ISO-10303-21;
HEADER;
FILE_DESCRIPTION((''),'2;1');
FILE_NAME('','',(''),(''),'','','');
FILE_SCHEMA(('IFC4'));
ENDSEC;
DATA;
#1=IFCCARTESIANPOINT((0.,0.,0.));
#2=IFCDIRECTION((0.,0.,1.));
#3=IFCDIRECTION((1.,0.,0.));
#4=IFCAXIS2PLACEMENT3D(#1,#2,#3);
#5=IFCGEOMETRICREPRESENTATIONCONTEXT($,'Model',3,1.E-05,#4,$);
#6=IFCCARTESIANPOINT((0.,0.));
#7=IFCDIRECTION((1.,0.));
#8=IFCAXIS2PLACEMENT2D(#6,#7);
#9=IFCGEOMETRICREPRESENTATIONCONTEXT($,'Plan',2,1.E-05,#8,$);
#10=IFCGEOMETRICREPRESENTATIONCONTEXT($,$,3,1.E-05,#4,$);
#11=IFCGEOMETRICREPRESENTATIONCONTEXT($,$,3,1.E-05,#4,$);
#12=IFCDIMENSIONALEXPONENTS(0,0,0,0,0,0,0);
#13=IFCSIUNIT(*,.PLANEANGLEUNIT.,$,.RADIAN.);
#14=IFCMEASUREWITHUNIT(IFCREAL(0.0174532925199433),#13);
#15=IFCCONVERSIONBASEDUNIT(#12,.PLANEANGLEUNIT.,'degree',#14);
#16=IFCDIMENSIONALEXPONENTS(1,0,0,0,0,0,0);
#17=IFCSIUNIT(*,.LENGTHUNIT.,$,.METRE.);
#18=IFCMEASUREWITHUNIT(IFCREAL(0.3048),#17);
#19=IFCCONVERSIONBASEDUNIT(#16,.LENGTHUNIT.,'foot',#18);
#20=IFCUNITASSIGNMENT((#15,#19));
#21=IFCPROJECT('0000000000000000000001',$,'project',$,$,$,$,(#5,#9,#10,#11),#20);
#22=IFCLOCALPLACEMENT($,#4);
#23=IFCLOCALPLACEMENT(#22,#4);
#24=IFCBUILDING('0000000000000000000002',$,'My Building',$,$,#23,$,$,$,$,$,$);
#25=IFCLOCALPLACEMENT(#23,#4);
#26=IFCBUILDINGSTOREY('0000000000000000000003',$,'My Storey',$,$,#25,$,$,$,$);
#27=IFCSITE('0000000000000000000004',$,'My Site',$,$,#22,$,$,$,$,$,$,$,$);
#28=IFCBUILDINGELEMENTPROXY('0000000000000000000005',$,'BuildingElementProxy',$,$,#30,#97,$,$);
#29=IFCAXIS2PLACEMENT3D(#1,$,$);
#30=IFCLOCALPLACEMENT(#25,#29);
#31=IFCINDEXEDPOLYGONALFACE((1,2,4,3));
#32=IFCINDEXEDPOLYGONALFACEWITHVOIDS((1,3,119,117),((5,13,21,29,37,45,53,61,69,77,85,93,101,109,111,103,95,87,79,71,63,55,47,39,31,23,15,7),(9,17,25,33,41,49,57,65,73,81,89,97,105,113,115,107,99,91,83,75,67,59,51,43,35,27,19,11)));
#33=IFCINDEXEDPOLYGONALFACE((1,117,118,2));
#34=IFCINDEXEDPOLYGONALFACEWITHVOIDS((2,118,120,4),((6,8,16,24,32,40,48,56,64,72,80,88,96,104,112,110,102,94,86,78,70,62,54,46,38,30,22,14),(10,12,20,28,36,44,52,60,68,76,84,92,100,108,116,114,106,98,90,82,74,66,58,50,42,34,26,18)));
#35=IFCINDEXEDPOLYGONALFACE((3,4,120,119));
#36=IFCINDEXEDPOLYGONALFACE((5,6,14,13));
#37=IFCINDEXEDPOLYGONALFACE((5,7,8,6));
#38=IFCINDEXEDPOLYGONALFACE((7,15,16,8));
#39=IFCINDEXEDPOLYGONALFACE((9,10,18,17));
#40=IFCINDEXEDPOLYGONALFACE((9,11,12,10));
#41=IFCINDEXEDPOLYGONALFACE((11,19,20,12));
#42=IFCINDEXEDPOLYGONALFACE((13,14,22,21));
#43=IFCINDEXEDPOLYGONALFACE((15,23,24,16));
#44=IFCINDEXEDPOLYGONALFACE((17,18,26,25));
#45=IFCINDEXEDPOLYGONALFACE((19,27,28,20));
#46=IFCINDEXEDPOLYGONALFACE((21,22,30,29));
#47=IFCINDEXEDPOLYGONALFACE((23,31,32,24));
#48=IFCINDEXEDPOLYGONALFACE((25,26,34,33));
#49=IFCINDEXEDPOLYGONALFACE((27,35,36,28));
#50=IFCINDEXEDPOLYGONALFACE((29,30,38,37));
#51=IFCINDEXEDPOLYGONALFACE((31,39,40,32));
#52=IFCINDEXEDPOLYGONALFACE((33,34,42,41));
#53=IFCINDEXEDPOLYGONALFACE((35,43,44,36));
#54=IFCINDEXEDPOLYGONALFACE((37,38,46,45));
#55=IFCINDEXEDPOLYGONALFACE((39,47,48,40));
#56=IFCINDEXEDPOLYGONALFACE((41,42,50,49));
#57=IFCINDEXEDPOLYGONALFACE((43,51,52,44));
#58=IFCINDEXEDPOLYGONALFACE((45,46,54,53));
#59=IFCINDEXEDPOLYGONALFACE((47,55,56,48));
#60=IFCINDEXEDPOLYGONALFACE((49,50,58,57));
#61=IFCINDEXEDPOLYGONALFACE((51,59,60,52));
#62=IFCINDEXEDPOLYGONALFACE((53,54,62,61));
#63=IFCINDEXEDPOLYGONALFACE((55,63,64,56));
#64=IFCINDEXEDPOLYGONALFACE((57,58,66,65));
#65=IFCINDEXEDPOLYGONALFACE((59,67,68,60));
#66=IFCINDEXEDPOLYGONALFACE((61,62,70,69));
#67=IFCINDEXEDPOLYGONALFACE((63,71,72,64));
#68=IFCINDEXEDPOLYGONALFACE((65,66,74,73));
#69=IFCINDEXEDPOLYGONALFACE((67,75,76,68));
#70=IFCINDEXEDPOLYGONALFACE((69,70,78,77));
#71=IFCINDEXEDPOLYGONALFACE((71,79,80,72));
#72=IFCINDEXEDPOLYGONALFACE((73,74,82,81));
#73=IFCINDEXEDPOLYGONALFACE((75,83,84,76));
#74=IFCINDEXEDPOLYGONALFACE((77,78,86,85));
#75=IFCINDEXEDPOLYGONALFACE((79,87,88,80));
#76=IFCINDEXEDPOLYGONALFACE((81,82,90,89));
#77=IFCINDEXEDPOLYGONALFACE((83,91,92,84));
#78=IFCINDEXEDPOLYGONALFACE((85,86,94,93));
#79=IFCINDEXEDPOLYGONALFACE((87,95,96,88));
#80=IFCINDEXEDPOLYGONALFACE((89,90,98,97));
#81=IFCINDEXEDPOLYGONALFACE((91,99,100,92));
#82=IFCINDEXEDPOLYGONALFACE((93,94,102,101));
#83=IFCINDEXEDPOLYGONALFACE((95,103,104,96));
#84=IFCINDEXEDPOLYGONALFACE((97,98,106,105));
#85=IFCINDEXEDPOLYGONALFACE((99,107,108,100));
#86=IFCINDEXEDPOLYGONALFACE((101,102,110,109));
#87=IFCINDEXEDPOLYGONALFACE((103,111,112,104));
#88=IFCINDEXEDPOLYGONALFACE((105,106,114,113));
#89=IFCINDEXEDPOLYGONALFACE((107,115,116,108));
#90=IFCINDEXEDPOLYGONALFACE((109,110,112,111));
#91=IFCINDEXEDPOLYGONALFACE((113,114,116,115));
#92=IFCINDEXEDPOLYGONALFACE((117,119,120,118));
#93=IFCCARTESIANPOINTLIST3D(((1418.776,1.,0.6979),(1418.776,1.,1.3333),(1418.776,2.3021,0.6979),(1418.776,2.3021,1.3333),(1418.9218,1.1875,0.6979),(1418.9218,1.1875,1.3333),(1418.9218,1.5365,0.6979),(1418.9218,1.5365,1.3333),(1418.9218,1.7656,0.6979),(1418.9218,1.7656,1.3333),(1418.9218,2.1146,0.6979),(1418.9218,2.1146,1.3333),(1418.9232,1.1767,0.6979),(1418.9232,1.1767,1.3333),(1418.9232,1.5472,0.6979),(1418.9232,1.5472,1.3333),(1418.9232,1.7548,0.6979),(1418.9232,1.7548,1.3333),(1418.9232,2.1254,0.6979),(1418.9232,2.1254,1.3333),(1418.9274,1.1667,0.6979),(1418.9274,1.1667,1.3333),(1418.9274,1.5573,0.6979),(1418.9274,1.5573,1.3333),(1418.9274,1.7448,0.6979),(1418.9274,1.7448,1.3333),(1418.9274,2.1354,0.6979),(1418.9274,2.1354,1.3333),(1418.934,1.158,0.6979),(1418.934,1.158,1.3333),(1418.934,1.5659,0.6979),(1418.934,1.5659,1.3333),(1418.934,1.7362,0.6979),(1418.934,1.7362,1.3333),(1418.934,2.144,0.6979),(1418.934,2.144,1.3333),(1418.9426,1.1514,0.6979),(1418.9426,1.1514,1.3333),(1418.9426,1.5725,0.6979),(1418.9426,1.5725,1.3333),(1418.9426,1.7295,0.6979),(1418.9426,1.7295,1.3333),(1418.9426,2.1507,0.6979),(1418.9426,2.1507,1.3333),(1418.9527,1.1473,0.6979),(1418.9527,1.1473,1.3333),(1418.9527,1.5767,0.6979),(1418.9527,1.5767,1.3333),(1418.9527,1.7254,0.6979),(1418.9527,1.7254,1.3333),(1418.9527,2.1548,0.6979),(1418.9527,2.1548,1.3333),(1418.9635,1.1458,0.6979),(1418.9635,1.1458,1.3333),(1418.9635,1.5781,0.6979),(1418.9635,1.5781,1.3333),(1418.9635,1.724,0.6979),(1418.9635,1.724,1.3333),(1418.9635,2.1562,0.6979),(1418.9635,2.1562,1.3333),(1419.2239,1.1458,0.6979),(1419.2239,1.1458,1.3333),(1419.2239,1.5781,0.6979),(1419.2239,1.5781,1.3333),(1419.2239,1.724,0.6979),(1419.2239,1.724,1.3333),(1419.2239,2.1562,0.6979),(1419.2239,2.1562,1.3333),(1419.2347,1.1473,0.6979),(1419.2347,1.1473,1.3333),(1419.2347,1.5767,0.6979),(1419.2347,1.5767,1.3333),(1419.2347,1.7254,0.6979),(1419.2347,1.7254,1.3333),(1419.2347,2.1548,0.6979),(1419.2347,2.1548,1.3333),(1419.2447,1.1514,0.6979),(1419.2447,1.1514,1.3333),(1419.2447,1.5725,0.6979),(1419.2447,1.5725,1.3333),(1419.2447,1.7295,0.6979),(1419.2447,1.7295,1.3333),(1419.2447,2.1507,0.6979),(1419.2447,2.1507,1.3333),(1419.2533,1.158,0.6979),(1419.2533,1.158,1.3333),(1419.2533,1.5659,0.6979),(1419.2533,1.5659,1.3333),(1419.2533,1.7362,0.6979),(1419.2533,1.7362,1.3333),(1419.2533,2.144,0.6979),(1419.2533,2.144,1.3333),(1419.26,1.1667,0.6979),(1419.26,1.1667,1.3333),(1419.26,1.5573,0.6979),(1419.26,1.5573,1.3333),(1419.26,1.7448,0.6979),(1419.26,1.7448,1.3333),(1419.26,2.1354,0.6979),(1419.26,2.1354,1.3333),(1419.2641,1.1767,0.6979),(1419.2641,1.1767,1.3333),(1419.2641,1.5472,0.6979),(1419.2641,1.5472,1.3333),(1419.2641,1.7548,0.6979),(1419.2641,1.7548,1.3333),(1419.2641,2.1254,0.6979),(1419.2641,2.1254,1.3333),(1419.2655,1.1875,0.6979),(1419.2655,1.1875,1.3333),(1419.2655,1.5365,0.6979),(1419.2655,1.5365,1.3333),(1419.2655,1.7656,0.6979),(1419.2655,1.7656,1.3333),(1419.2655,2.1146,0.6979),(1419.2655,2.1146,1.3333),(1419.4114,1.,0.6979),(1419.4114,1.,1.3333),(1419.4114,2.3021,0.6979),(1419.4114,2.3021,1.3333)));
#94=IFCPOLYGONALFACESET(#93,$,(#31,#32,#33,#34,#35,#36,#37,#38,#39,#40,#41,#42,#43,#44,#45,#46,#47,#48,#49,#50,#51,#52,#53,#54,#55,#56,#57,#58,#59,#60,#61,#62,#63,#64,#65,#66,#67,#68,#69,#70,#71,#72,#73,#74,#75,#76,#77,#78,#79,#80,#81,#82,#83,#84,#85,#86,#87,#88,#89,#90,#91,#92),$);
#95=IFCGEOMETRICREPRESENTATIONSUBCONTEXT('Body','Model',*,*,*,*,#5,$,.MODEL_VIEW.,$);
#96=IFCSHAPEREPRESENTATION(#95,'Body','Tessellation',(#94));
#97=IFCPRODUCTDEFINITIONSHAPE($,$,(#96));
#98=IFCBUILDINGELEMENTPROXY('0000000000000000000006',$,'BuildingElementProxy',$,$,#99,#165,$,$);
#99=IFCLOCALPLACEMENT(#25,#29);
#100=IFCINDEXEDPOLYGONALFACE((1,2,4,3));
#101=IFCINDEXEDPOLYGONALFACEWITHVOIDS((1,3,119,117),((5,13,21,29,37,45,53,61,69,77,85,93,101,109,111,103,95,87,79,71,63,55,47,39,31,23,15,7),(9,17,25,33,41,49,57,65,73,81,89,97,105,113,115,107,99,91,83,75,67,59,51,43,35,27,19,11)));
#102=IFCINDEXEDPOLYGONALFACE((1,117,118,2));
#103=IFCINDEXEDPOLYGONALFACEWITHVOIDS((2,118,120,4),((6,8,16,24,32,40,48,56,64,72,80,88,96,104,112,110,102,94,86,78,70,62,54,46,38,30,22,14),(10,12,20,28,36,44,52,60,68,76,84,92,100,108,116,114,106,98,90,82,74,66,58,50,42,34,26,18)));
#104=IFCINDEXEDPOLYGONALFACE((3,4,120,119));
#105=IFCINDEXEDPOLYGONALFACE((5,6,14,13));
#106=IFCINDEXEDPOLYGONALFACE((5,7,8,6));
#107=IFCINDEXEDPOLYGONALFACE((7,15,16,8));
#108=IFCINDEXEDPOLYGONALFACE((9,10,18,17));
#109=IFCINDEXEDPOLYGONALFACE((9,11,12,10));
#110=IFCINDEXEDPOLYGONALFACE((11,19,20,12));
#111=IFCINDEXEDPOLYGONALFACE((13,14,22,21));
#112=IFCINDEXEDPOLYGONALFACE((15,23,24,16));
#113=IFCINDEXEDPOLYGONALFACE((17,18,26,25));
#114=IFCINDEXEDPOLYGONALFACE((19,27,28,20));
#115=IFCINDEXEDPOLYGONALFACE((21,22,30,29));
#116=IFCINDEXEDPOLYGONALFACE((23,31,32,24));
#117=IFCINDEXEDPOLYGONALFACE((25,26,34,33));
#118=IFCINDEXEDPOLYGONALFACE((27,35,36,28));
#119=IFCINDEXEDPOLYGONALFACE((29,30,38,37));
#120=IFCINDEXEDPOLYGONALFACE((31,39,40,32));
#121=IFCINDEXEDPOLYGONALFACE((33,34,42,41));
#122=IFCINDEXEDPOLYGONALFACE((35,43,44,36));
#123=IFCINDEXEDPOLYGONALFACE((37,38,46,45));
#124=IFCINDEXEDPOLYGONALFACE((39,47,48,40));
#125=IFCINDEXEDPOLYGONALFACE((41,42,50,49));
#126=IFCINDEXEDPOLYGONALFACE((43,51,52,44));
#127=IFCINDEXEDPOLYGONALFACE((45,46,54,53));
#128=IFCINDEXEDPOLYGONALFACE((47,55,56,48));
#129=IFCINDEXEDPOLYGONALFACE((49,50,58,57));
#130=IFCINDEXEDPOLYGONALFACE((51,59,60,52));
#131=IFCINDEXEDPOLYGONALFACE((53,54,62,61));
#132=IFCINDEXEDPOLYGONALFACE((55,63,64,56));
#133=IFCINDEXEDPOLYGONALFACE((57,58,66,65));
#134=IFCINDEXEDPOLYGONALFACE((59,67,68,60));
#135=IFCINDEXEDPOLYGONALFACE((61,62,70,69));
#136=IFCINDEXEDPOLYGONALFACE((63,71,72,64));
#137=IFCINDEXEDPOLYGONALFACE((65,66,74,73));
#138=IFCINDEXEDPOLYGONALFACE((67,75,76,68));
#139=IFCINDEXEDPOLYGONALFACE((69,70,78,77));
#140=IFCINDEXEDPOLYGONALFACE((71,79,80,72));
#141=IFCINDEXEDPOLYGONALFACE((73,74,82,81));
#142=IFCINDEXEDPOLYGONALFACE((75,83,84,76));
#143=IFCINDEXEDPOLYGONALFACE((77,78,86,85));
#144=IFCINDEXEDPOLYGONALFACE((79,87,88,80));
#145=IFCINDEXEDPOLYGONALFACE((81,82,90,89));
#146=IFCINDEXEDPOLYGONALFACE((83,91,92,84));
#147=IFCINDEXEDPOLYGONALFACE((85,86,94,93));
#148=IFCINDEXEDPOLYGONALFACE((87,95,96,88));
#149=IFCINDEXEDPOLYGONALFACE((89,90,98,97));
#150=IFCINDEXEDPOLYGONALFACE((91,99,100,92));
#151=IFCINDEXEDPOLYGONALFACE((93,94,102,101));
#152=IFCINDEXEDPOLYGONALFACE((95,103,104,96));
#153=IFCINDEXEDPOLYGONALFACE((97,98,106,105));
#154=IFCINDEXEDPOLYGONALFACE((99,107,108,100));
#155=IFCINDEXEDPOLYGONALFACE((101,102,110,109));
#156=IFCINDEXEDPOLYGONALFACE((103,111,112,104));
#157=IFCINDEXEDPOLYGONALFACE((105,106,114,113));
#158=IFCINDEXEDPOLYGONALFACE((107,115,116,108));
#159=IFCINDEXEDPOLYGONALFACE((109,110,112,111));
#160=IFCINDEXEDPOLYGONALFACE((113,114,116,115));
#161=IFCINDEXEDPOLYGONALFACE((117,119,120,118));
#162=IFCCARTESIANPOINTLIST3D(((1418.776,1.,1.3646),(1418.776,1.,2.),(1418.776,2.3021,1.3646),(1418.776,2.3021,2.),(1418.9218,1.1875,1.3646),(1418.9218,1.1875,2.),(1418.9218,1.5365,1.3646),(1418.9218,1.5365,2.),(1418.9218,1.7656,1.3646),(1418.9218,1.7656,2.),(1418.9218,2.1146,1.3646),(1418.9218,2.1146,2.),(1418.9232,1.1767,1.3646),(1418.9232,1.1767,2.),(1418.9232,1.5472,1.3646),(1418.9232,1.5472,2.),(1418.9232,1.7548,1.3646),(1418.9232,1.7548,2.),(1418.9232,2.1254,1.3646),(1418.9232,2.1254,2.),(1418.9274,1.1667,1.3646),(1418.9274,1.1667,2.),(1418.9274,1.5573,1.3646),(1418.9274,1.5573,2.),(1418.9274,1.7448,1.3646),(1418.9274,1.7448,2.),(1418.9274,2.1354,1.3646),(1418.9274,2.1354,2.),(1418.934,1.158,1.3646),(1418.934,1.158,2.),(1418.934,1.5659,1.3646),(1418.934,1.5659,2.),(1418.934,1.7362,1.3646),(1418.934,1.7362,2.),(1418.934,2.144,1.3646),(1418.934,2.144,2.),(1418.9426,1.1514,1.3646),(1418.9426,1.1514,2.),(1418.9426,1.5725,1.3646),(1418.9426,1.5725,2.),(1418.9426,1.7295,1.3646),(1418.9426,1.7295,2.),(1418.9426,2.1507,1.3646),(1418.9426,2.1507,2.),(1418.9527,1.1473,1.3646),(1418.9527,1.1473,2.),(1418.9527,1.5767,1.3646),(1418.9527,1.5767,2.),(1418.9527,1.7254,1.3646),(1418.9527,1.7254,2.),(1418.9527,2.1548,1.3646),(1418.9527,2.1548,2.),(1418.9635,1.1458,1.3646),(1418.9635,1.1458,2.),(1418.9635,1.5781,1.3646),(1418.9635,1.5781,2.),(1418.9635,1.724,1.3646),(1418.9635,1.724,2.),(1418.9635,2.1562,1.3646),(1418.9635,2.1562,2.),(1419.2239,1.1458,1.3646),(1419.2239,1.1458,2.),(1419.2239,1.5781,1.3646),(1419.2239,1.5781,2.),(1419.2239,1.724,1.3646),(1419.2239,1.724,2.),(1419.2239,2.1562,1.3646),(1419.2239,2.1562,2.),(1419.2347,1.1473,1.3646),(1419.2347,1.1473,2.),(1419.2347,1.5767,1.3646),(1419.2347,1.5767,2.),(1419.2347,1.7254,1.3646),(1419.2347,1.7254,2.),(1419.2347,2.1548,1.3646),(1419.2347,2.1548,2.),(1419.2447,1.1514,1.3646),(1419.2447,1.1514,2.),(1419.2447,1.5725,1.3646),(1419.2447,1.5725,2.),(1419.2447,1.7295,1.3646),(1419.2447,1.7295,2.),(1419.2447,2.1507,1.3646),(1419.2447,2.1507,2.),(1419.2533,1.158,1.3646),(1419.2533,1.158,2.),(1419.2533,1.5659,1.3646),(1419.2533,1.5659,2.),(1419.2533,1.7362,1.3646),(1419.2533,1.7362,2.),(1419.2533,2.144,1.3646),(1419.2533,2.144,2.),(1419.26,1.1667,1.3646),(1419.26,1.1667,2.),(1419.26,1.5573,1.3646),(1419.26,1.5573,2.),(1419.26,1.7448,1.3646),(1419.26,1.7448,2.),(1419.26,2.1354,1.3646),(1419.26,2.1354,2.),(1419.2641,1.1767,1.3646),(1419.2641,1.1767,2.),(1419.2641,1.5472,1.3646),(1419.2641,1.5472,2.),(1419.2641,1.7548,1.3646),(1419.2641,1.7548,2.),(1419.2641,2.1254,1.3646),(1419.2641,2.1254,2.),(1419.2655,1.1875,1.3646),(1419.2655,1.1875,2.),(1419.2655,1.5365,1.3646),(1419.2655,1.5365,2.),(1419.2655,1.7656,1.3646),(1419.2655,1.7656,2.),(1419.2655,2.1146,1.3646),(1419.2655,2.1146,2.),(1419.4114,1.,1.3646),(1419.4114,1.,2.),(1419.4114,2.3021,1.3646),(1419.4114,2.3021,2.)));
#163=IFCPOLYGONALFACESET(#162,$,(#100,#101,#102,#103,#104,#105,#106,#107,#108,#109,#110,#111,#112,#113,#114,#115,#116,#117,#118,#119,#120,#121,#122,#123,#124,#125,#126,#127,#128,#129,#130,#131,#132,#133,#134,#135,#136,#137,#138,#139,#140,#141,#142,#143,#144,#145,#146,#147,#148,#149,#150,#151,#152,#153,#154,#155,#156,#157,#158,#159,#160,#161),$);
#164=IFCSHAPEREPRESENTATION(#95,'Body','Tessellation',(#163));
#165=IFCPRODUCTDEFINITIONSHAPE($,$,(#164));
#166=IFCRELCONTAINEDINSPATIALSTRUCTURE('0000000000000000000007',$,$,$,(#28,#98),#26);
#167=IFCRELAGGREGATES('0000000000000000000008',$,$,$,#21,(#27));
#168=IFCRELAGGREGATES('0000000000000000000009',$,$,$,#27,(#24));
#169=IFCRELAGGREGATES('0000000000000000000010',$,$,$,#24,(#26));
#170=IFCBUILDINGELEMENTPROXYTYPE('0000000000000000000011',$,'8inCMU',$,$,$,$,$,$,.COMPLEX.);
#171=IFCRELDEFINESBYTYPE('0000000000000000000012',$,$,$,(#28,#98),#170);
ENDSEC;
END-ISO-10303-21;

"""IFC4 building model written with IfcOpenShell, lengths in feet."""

from ifc_helpers import new_model, entity, si_unit, converted_unit, frame, origin_with_axes, origin_2d_with_axis, place, context, subcontext, project, spatial, line, indexed_curve, outline, extrude, source, transform, mapped, type_object, type_shapes, element, save


model = new_model("IFC4")

# Units and contexts
model_context_1 = context("Model", 3, precision=1e-05, world=origin_with_axes())
plan_context = context("Plan", 2, precision=1e-05, world=origin_2d_with_axis())
context_of_model_1 = context(None, 3, precision=1e-05, world=origin_with_axes())
context_of_model_2 = context(None, 3, precision=1e-05, world=origin_with_axes())
body_context_1 = subcontext(model_context_1, "Body", "Model", "MODEL_VIEW")
ifc_project = project(units=[converted_unit("PLANEANGLEUNIT", "degree", entity("IfcReal", 0.0174532925199433), si_unit("PLANEANGLEUNIT", "RADIAN"), dimensions=[0, 0, 0, 0, 0, 0, 0]), converted_unit("LENGTHUNIT", "foot", entity("IfcReal", 0.3048), si_unit("LENGTHUNIT", "METRE"), dimensions=[1, 0, 0, 0, 0, 0, 0])], contexts=[model_context_1, plan_context, context_of_model_1, context_of_model_2])

# Site, building, storey
site_placement = place(None, origin_with_axes())
site = spatial("IfcSite", under=ifc_project, at=site_placement, Name="My Site")
building_placement = place(site_placement, origin_with_axes())
building = spatial("IfcBuilding", under=site, at=building_placement, Name="My Building")
storey_placement = place(building_placement, origin_with_axes())
storey = spatial("IfcBuildingStorey", under=building, at=storey_placement, Name="My Storey")

# Building element proxies
building_element_proxy_type_1 = type_object("IfcBuildingElementProxyType", Name="8inCMU", PredefinedType="COMPLEX")
shared_shape_1 = source(origin_with_axes(), body_context_1, "Body", "SweptSolid", [
    extrude(outline(indexed_curve([(-0.3177, -0.651), (0.3177, -0.651), (0.3177, 0.651), (-0.3177, 0.651), (0.1719, -0.1146), (0.1719, -0.4635), (0.1705, -0.4743), (0.1663, -0.4844), (0.1597, -0.493), (0.151, -0.4996), (0.141, -0.5038), (0.1302, -0.5052), (-0.1302, -0.5052), (-0.141, -0.5038), (-0.151, -0.4996), (-0.1597, -0.493), (-0.1663, -0.4844), (-0.1705, -0.4743), (-0.1719, -0.4635), (-0.1719, -0.1146), (-0.1705, -0.1038), (-0.1663, -0.0938), (-0.1597, -0.0851), (-0.151, -0.0785), (-0.141, -0.0743), (-0.1302, -0.0729), (0.1302, -0.0729), (0.141, -0.0743), (0.151, -0.0785), (0.1597, -0.0851), (0.1663, -0.0938), (0.1705, -0.1038), (0.151, 0.0785), (0.141, 0.0743), (0.1302, 0.0729), (-0.1302, 0.0729), (-0.141, 0.0743), (-0.151, 0.0785), (-0.1597, 0.0851), (-0.1663, 0.0937), (-0.1705, 0.1038), (-0.1719, 0.1146), (-0.1719, 0.4635), (-0.1705, 0.4743), (-0.1663, 0.4844), (-0.1597, 0.493), (-0.151, 0.4996), (-0.141, 0.5038), (-0.1302, 0.5052), (0.1302, 0.5052), (0.141, 0.5038), (0.151, 0.4996), (0.1597, 0.493), (0.1663, 0.4844), (0.1705, 0.4743), (0.1719, 0.4635), (0.1719, 0.1146), (0.1705, 0.1038), (0.1663, 0.0937), (0.1597, 0.0851)], segments=[line(4, 3), line(3, 2), line(2, 1), line(1, 4)], self_intersect=False), holes=[indexed_curve([(-0.3177, -0.651), (0.3177, -0.651), (0.3177, 0.651), (-0.3177, 0.651), (0.1719, -0.1146), (0.1719, -0.4635), (0.1705, -0.4743), (0.1663, -0.4844), (0.1597, -0.493), (0.151, -0.4996), (0.141, -0.5038), (0.1302, -0.5052), (-0.1302, -0.5052), (-0.141, -0.5038), (-0.151, -0.4996), (-0.1597, -0.493), (-0.1663, -0.4844), (-0.1705, -0.4743), (-0.1719, -0.4635), (-0.1719, -0.1146), (-0.1705, -0.1038), (-0.1663, -0.0938), (-0.1597, -0.0851), (-0.151, -0.0785), (-0.141, -0.0743), (-0.1302, -0.0729), (0.1302, -0.0729), (0.141, -0.0743), (0.151, -0.0785), (0.1597, -0.0851), (0.1663, -0.0938), (0.1705, -0.1038), (0.151, 0.0785), (0.141, 0.0743), (0.1302, 0.0729), (-0.1302, 0.0729), (-0.141, 0.0743), (-0.151, 0.0785), (-0.1597, 0.0851), (-0.1663, 0.0937), (-0.1705, 0.1038), (-0.1719, 0.1146), (-0.1719, 0.4635), (-0.1705, 0.4743), (-0.1663, 0.4844), (-0.1597, 0.493), (-0.151, 0.4996), (-0.141, 0.5038), (-0.1302, 0.5052), (0.1302, 0.5052), (0.141, 0.5038), (0.151, 0.4996), (0.1597, 0.493), (0.1663, 0.4844), (0.1705, 0.4743), (0.1719, 0.4635), (0.1719, 0.1146), (0.1705, 0.1038), (0.1663, 0.0937), (0.1597, 0.0851)], segments=[line(20, 19), line(19, 18), line(18, 17), line(17, 16), line(16, 15), line(15, 14), line(14, 13), line(13, 12), line(12, 11), line(11, 10), line(10, 9), line(9, 8), line(8, 7), line(7, 6), line(6, 5), line(5, 32), line(32, 31), line(31, 30), line(30, 29), line(29, 28), line(28, 27), line(27, 26), line(26, 25), line(25, 24), line(24, 23), line(23, 22), line(22, 21), line(21, 20)], self_intersect=False), indexed_curve([(-0.3177, -0.651), (0.3177, -0.651), (0.3177, 0.651), (-0.3177, 0.651), (0.1719, -0.1146), (0.1719, -0.4635), (0.1705, -0.4743), (0.1663, -0.4844), (0.1597, -0.493), (0.151, -0.4996), (0.141, -0.5038), (0.1302, -0.5052), (-0.1302, -0.5052), (-0.141, -0.5038), (-0.151, -0.4996), (-0.1597, -0.493), (-0.1663, -0.4844), (-0.1705, -0.4743), (-0.1719, -0.4635), (-0.1719, -0.1146), (-0.1705, -0.1038), (-0.1663, -0.0938), (-0.1597, -0.0851), (-0.151, -0.0785), (-0.141, -0.0743), (-0.1302, -0.0729), (0.1302, -0.0729), (0.141, -0.0743), (0.151, -0.0785), (0.1597, -0.0851), (0.1663, -0.0938), (0.1705, -0.1038), (0.151, 0.0785), (0.141, 0.0743), (0.1302, 0.0729), (-0.1302, 0.0729), (-0.141, 0.0743), (-0.151, 0.0785), (-0.1597, 0.0851), (-0.1663, 0.0937), (-0.1705, 0.1038), (-0.1719, 0.1146), (-0.1719, 0.4635), (-0.1705, 0.4743), (-0.1663, 0.4844), (-0.1597, 0.493), (-0.151, 0.4996), (-0.141, 0.5038), (-0.1302, 0.5052), (0.1302, 0.5052), (0.141, 0.5038), (0.151, 0.4996), (0.1597, 0.493), (0.1663, 0.4844), (0.1705, 0.4743), (0.1719, 0.4635), (0.1719, 0.1146), (0.1705, 0.1038), (0.1663, 0.0937), (0.1597, 0.0851)], segments=[line(44, 43), line(43, 42), line(42, 41), line(41, 40), line(40, 39), line(39, 38), line(38, 37), line(37, 36), line(36, 35), line(35, 34), line(34, 33), line(33, 60), line(60, 59), line(59, 58), line(58, 57), line(57, 56), line(56, 55), line(55, 54), line(54, 53), line(53, 52), line(52, 51), line(51, 50), line(50, 49), line(49, 48), line(48, 47), line(47, 46), line(46, 45), line(45, 44)], self_intersect=False)]), frame((-0.651, 0.0, 0.0), z_axis=(0.0, 0.0, 1.0), x_axis=(0.0, -1.0, 0.0)), (0.0, 0.0, 1.0), 0.6354),
])
type_shapes(building_element_proxy_type_1, [shared_shape_1])
for number, where, z_axis, x_axis, name in (
    (1, (1419.0936, 2.3021, 0.6979), (0.0, 0.0, 1.0), (0.0, 1.0, 0.0), "BuildingElementProxy"),
    (2, (1419.0936, 2.3021, 1.3646), (0.0, 0.0, 1.0), (0.0, 1.0, 0.0), "BuildingElementProxy"),
):
    element("IfcBuildingElementProxy", number, at=place(storey_placement, frame(where, z_axis=z_axis, x_axis=x_axis)), inside=storey, type_object=building_element_proxy_type_1, Name=name, context=body_context_1, shape_type="MappedRepresentation", body=[
        mapped(shared_shape_1, transform((0.0, 0.0, 0.0), x_axis=(1.0, 0.0, 0.0), y_axis=(0.0, 1.0, 0.0), z_axis=(0.0, 0.0, 1.0), scale=1.0)),
    ])

save(model, "model.ifc")
